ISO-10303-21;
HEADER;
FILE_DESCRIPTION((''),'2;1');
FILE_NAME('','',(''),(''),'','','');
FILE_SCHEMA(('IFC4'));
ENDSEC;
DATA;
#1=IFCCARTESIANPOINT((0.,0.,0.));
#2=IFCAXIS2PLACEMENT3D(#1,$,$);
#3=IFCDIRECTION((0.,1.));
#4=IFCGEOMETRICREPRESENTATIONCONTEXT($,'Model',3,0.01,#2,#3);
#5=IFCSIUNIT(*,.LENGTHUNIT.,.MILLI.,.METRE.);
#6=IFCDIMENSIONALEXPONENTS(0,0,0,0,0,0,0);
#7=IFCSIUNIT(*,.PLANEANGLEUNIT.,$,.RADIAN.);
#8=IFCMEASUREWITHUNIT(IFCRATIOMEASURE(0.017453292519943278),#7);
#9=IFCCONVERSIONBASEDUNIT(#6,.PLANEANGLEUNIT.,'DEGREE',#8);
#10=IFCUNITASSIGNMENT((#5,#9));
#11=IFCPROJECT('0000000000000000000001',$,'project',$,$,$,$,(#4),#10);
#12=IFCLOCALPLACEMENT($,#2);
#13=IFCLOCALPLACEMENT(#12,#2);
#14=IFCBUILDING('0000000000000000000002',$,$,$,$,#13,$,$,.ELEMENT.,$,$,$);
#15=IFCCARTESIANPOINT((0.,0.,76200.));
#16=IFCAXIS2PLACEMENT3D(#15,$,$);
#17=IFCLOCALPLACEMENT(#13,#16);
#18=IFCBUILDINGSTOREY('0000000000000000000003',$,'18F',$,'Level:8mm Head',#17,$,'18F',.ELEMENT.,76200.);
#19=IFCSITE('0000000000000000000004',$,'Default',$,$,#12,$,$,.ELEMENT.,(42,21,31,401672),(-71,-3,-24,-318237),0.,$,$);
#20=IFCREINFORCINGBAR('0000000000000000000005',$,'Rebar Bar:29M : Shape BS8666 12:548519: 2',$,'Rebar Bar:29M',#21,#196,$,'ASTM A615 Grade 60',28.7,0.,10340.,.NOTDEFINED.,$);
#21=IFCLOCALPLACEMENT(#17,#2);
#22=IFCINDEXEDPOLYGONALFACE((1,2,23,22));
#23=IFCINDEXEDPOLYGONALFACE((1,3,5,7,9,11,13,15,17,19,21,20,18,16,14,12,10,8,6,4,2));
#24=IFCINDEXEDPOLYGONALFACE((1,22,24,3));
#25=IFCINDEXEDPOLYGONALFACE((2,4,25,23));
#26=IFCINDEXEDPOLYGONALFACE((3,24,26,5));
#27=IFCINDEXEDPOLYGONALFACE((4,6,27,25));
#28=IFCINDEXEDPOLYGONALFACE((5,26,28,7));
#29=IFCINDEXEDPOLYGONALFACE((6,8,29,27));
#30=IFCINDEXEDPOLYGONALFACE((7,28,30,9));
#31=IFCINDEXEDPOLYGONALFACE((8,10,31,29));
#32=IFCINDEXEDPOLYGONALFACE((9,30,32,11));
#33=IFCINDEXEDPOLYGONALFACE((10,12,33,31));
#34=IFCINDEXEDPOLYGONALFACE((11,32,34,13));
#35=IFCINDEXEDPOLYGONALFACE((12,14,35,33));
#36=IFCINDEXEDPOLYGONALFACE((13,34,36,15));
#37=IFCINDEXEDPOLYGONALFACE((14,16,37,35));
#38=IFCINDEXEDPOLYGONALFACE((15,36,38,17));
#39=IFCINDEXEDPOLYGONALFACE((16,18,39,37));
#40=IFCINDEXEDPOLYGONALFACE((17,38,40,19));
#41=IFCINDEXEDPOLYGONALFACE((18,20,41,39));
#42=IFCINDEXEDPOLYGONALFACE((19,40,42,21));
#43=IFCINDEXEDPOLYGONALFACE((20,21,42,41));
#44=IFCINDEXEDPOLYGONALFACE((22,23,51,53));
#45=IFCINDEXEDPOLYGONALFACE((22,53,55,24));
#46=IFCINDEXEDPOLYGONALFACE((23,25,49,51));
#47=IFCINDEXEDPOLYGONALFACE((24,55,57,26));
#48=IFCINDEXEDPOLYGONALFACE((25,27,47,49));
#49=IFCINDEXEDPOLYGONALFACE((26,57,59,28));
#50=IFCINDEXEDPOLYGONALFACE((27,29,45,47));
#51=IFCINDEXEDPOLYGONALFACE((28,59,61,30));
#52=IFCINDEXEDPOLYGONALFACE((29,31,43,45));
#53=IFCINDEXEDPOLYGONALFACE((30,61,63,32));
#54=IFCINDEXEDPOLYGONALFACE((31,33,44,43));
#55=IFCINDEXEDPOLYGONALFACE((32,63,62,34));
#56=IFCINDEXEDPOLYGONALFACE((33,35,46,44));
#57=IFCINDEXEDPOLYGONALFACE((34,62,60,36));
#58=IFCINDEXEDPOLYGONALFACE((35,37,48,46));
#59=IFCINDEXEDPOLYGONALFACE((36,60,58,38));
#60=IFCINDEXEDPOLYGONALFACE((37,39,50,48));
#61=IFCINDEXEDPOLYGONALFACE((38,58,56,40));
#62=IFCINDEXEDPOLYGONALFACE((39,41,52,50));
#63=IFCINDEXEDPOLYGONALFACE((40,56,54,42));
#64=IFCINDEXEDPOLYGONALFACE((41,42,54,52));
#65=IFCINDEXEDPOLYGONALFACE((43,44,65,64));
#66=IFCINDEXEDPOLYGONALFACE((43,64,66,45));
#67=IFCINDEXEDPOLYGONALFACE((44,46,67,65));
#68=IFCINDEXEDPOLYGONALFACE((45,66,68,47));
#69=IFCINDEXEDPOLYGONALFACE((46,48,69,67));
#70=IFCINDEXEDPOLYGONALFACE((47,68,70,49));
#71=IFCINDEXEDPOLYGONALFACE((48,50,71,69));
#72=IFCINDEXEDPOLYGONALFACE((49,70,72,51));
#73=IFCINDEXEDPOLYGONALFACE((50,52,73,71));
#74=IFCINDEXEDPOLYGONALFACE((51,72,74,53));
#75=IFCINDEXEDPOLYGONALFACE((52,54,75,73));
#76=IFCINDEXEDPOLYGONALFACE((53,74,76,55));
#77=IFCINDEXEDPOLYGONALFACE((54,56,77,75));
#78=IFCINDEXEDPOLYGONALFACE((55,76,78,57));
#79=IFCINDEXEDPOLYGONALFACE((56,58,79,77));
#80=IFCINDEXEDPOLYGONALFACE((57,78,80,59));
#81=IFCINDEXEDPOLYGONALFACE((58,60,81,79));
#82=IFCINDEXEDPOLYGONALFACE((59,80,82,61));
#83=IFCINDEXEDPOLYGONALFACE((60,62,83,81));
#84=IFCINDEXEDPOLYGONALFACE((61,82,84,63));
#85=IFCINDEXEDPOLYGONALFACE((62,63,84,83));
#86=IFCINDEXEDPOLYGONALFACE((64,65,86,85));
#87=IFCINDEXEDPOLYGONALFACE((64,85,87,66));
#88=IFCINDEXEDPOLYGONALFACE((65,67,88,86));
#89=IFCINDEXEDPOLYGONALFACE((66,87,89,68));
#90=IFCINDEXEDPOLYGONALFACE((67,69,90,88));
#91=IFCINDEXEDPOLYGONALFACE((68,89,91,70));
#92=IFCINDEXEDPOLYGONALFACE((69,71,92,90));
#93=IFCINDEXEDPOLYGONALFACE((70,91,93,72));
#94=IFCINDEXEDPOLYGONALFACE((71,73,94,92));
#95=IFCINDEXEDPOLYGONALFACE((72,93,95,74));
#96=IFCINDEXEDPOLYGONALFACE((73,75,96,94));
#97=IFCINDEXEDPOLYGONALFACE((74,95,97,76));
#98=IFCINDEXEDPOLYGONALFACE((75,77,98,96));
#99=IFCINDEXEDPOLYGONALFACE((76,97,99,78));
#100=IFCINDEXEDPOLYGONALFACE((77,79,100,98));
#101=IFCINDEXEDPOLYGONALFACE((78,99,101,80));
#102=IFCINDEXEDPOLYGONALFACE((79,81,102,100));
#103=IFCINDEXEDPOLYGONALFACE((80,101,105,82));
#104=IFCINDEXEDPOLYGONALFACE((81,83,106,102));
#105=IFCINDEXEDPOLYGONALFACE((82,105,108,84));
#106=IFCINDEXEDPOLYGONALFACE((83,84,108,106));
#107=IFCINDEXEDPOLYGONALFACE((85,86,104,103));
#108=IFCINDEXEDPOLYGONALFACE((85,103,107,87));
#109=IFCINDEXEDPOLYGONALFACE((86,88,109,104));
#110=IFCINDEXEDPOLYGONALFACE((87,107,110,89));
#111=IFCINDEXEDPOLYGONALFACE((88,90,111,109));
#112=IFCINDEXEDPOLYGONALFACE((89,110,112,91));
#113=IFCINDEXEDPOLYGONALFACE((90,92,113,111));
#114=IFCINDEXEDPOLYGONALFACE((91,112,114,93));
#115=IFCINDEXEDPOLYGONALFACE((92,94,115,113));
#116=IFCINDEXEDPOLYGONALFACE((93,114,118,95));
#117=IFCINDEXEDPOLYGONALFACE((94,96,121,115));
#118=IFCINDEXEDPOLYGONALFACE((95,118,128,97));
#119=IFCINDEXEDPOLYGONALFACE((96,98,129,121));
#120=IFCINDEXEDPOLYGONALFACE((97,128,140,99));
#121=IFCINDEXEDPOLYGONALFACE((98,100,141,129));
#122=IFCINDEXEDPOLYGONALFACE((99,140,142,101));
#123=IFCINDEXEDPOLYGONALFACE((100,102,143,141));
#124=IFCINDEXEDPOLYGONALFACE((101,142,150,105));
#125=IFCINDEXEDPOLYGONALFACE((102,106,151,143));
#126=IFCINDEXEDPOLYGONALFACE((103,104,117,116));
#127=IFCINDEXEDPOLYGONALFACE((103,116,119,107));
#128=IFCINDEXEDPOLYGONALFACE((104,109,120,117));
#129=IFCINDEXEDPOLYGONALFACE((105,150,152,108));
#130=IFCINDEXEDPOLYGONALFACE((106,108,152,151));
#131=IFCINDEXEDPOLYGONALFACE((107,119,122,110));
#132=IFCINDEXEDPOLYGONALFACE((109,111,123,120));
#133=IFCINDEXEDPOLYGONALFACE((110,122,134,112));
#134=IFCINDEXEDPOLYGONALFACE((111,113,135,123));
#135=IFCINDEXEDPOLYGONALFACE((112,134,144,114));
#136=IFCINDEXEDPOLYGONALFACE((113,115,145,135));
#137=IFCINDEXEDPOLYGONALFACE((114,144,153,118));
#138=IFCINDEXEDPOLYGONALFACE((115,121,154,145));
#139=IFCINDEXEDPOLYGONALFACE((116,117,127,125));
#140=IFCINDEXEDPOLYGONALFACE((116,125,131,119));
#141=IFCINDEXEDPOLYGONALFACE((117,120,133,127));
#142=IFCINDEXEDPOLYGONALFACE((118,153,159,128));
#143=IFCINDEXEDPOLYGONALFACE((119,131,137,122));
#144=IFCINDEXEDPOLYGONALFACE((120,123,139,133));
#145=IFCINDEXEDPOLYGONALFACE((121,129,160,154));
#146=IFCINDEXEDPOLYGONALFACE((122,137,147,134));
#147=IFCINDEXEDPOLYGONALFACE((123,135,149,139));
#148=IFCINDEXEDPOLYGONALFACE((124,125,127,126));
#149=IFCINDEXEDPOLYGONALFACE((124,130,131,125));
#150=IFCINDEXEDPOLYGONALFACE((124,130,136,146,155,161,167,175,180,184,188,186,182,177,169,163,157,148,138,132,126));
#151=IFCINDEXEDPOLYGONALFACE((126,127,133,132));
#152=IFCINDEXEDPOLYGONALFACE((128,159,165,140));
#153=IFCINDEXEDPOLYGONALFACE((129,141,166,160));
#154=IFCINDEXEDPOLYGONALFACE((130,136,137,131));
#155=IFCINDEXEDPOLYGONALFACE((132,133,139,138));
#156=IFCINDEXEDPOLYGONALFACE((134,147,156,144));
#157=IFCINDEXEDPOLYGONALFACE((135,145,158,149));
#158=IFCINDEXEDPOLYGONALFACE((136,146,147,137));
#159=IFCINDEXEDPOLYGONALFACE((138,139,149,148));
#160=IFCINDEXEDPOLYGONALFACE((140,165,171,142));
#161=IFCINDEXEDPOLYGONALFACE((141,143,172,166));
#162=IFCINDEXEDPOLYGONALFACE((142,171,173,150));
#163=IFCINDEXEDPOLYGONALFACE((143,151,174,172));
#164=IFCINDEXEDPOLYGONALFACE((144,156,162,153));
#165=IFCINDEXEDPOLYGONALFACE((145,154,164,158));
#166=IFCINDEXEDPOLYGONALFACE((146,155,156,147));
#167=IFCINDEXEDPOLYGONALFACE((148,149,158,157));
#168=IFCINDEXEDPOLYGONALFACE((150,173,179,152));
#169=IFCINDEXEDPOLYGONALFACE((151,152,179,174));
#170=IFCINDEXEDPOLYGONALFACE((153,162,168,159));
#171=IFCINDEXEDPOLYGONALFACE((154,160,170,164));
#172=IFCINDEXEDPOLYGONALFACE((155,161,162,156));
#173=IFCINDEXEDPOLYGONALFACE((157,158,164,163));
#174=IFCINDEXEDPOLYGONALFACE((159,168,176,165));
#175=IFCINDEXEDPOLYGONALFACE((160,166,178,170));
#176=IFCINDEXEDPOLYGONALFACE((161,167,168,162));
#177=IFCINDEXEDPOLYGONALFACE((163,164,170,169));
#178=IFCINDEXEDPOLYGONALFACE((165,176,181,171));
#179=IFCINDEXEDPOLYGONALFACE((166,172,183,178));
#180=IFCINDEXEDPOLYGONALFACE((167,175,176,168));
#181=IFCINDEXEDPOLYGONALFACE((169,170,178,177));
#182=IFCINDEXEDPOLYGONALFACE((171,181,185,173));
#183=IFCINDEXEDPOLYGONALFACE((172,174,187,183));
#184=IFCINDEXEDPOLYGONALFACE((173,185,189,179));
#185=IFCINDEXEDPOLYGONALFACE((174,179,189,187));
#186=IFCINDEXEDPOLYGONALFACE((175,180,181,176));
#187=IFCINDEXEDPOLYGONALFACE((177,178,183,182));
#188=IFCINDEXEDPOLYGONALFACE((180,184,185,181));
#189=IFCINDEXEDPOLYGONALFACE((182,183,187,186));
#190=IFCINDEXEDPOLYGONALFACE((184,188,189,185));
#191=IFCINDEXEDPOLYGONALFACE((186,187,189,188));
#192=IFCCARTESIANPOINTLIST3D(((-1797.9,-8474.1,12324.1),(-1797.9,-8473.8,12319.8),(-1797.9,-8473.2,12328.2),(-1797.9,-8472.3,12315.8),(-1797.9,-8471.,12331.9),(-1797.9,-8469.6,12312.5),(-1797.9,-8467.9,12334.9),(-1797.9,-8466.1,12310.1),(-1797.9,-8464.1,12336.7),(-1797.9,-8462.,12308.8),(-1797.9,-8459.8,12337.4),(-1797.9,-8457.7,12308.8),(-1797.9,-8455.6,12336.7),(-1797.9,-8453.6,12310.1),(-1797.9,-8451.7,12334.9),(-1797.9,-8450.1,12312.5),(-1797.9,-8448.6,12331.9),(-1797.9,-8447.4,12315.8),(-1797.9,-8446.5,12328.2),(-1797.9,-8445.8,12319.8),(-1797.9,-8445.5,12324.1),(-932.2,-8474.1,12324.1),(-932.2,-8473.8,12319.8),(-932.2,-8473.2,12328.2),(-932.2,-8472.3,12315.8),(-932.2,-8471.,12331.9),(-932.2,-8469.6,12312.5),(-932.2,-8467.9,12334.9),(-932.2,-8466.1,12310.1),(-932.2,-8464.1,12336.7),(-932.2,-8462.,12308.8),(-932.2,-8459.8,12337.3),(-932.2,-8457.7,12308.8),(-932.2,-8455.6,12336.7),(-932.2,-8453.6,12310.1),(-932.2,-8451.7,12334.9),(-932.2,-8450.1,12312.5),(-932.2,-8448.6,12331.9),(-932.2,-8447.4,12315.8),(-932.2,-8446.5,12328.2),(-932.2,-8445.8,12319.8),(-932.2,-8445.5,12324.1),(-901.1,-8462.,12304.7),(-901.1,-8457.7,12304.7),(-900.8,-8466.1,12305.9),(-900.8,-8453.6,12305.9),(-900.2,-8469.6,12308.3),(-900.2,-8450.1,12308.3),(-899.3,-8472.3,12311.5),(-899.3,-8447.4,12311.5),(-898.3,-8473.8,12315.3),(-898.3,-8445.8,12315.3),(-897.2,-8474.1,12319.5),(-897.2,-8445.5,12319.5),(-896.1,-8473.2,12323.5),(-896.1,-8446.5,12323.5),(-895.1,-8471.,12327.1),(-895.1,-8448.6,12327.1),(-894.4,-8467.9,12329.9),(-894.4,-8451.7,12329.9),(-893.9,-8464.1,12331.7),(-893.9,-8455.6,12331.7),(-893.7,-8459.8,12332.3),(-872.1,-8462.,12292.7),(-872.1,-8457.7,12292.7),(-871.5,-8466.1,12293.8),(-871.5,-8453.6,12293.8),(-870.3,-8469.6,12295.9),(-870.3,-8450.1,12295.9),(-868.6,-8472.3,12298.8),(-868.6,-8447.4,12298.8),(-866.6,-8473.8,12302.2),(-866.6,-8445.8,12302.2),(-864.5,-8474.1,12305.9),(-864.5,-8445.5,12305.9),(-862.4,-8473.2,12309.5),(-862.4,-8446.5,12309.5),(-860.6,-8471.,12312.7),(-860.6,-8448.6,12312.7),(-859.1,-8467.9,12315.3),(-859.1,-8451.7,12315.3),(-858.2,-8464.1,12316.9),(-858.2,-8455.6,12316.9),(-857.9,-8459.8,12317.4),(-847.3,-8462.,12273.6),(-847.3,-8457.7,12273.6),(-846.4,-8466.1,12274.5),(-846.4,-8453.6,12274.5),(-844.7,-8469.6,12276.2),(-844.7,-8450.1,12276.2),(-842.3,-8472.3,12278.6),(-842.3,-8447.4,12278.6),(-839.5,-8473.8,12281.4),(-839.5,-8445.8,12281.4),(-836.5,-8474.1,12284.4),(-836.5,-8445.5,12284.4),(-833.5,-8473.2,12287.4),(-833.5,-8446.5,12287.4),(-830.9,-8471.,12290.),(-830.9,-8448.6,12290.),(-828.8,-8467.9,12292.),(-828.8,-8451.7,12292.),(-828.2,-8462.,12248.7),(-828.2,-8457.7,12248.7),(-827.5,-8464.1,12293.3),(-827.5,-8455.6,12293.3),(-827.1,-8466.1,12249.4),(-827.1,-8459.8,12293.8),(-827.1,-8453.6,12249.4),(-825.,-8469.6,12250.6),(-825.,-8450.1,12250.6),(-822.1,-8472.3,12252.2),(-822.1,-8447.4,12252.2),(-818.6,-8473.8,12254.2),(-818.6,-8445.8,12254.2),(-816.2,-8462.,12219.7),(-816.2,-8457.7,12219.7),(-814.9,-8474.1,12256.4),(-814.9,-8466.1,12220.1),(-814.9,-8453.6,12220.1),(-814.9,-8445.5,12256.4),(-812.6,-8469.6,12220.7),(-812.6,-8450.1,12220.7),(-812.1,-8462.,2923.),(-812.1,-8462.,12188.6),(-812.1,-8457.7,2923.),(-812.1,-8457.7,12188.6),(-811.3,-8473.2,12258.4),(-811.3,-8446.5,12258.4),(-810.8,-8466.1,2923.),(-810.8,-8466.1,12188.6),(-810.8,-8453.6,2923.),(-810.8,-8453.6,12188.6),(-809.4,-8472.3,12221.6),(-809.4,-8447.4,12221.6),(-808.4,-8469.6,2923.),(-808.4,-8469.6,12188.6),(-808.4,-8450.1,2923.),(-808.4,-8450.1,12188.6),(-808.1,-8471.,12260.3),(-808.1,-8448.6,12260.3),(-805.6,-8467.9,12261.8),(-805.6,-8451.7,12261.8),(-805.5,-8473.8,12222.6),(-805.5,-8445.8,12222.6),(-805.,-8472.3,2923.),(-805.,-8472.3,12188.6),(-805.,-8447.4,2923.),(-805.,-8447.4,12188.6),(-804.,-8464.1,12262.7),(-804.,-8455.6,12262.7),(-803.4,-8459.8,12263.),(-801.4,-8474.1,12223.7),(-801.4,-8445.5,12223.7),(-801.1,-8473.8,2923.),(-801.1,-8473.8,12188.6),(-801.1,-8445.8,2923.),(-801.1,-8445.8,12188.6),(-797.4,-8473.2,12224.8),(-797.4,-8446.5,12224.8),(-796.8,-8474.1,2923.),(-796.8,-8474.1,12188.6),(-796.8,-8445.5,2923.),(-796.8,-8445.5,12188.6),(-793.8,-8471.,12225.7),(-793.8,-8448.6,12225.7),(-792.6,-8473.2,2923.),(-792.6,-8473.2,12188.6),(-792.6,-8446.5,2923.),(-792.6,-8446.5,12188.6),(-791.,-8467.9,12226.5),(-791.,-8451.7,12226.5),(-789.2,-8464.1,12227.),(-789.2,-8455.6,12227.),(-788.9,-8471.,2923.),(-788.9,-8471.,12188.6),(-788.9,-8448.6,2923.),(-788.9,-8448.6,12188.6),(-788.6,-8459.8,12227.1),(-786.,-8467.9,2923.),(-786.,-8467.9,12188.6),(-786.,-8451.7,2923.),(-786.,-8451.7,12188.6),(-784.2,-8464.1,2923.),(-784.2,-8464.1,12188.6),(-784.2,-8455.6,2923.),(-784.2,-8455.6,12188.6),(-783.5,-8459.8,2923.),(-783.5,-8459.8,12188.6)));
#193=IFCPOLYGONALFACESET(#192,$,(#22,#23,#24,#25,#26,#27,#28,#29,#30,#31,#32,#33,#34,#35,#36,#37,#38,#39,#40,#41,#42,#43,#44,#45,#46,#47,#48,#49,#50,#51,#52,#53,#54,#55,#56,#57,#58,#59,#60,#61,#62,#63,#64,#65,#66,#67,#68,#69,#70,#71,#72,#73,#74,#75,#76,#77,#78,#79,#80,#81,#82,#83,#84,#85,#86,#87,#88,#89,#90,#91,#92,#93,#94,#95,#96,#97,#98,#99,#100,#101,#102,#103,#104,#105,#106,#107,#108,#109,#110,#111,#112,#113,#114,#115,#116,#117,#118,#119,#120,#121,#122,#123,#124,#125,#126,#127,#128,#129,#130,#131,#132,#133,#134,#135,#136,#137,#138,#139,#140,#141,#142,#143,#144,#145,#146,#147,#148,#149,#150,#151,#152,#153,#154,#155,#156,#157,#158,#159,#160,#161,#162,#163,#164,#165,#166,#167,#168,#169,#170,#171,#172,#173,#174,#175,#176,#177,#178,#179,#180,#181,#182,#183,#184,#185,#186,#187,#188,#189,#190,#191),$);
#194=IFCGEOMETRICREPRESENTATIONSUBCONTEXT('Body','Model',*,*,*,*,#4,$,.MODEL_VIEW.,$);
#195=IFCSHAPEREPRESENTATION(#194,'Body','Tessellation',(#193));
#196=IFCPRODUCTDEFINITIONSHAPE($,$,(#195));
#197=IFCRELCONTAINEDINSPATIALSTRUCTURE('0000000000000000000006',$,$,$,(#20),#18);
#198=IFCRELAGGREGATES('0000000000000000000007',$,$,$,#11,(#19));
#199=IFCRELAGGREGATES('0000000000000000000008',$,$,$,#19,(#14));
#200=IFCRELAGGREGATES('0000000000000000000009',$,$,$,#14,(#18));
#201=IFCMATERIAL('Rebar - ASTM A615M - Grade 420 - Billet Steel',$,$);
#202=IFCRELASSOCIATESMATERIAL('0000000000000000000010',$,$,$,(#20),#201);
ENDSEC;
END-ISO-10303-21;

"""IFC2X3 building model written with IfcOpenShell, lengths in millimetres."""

from ifc_helpers import new_model, entity, si_unit, converted_unit, direction, frame, origin, place, context, subcontext, project, spatial, material, element, save


model = new_model("IFC2X3")

# Units and contexts
model_context = context("Model", 3, precision=0.01, world=origin(), true_north=direction((0.0, 1.0)))
body_context = subcontext(model_context, "Body", "Model", "MODEL_VIEW")
ifc_project = project(units=[si_unit("LENGTHUNIT", "METRE", prefix="MILLI"), converted_unit("PLANEANGLEUNIT", "DEGREE", entity("IfcRatioMeasure", 0.017453292519943278), si_unit("PLANEANGLEUNIT", "RADIAN"), dimensions=[0, 0, 0, 0, 0, 0, 0])], contexts=[model_context])

# Site, building, storey
site_placement = place(None, origin())
site = spatial("IfcSite", under=ifc_project, at=site_placement, Name="Default", CompositionType="ELEMENT", RefLatitude=(42, 21, 31, 401672), RefLongitude=(-71, -3, -24, -318237), RefElevation=0.0)
building_placement = place(site_placement, origin())
building = spatial("IfcBuilding", under=site, at=building_placement, CompositionType="ELEMENT")
storey_placement = place(building_placement, frame((0.0, 0.0, 76200.0)))
storey = spatial("IfcBuildingStorey", under=building, at=storey_placement, Name="18F", ObjectType="Level:8mm Head", LongName="18F", CompositionType="ELEMENT", Elevation=76200.0)

# Reinforcing bar
ifc_material_1 = material(Name="Rebar - ASTM A615M - Grade 420 - Billet Steel")
reinforcing_bar_1_placement = place(storey_placement, origin())
element("IfcReinforcingBar", 1, at=reinforcing_bar_1_placement, inside=storey, material=ifc_material_1, Name="Rebar Bar:29M : Shape BS8666 12:548519: 2", SteelGrade="ASTM A615 Grade 60", ObjectType="Rebar Bar:29M", BarLength=10340.0, BarRole="NOTDEFINED", CrossSectionArea=0.0, NominalDiameter=28.7, context=body_context, shape_type="AdvancedSweptSolid", body=[
    entity("IfcSweptDiskSolid", entity("IfcCompositeCurve", [entity("IfcCompositeCurveSegment", "CONTINUOUS", True, entity("IfcPolyline", [entity("IfcCartesianPoint", [-797.9, -8459.8, 2923.0]), entity("IfcCartesianPoint", [-797.9, -8459.8, 12188.6])])), entity("IfcCompositeCurveSegment", "CONTINUOUS", True, entity("IfcTrimmedCurve", entity("IfcCircle", entity("IfcAxis2Placement3D", entity("IfcCartesianPoint", [-932.2, -8459.8, 12188.6]), entity("IfcDirection", [0.0, -1.0, 0.0]), entity("IfcDirection", [0.0, 0.0, 1.0])), 134.3), [entity("IfcParameterValue", 270.0)], [entity("IfcParameterValue", 360.0)], True, "PARAMETER")), entity("IfcCompositeCurveSegment", "CONTINUOUS", True, entity("IfcPolyline", [entity("IfcCartesianPoint", [-932.2, -8459.8, 12323.0]), entity("IfcCartesianPoint", [-1797.9, -8459.8, 12323.0])]))], False), 14.3, None, 0.0, 92.0),
])

save(model, "model.ifc")
